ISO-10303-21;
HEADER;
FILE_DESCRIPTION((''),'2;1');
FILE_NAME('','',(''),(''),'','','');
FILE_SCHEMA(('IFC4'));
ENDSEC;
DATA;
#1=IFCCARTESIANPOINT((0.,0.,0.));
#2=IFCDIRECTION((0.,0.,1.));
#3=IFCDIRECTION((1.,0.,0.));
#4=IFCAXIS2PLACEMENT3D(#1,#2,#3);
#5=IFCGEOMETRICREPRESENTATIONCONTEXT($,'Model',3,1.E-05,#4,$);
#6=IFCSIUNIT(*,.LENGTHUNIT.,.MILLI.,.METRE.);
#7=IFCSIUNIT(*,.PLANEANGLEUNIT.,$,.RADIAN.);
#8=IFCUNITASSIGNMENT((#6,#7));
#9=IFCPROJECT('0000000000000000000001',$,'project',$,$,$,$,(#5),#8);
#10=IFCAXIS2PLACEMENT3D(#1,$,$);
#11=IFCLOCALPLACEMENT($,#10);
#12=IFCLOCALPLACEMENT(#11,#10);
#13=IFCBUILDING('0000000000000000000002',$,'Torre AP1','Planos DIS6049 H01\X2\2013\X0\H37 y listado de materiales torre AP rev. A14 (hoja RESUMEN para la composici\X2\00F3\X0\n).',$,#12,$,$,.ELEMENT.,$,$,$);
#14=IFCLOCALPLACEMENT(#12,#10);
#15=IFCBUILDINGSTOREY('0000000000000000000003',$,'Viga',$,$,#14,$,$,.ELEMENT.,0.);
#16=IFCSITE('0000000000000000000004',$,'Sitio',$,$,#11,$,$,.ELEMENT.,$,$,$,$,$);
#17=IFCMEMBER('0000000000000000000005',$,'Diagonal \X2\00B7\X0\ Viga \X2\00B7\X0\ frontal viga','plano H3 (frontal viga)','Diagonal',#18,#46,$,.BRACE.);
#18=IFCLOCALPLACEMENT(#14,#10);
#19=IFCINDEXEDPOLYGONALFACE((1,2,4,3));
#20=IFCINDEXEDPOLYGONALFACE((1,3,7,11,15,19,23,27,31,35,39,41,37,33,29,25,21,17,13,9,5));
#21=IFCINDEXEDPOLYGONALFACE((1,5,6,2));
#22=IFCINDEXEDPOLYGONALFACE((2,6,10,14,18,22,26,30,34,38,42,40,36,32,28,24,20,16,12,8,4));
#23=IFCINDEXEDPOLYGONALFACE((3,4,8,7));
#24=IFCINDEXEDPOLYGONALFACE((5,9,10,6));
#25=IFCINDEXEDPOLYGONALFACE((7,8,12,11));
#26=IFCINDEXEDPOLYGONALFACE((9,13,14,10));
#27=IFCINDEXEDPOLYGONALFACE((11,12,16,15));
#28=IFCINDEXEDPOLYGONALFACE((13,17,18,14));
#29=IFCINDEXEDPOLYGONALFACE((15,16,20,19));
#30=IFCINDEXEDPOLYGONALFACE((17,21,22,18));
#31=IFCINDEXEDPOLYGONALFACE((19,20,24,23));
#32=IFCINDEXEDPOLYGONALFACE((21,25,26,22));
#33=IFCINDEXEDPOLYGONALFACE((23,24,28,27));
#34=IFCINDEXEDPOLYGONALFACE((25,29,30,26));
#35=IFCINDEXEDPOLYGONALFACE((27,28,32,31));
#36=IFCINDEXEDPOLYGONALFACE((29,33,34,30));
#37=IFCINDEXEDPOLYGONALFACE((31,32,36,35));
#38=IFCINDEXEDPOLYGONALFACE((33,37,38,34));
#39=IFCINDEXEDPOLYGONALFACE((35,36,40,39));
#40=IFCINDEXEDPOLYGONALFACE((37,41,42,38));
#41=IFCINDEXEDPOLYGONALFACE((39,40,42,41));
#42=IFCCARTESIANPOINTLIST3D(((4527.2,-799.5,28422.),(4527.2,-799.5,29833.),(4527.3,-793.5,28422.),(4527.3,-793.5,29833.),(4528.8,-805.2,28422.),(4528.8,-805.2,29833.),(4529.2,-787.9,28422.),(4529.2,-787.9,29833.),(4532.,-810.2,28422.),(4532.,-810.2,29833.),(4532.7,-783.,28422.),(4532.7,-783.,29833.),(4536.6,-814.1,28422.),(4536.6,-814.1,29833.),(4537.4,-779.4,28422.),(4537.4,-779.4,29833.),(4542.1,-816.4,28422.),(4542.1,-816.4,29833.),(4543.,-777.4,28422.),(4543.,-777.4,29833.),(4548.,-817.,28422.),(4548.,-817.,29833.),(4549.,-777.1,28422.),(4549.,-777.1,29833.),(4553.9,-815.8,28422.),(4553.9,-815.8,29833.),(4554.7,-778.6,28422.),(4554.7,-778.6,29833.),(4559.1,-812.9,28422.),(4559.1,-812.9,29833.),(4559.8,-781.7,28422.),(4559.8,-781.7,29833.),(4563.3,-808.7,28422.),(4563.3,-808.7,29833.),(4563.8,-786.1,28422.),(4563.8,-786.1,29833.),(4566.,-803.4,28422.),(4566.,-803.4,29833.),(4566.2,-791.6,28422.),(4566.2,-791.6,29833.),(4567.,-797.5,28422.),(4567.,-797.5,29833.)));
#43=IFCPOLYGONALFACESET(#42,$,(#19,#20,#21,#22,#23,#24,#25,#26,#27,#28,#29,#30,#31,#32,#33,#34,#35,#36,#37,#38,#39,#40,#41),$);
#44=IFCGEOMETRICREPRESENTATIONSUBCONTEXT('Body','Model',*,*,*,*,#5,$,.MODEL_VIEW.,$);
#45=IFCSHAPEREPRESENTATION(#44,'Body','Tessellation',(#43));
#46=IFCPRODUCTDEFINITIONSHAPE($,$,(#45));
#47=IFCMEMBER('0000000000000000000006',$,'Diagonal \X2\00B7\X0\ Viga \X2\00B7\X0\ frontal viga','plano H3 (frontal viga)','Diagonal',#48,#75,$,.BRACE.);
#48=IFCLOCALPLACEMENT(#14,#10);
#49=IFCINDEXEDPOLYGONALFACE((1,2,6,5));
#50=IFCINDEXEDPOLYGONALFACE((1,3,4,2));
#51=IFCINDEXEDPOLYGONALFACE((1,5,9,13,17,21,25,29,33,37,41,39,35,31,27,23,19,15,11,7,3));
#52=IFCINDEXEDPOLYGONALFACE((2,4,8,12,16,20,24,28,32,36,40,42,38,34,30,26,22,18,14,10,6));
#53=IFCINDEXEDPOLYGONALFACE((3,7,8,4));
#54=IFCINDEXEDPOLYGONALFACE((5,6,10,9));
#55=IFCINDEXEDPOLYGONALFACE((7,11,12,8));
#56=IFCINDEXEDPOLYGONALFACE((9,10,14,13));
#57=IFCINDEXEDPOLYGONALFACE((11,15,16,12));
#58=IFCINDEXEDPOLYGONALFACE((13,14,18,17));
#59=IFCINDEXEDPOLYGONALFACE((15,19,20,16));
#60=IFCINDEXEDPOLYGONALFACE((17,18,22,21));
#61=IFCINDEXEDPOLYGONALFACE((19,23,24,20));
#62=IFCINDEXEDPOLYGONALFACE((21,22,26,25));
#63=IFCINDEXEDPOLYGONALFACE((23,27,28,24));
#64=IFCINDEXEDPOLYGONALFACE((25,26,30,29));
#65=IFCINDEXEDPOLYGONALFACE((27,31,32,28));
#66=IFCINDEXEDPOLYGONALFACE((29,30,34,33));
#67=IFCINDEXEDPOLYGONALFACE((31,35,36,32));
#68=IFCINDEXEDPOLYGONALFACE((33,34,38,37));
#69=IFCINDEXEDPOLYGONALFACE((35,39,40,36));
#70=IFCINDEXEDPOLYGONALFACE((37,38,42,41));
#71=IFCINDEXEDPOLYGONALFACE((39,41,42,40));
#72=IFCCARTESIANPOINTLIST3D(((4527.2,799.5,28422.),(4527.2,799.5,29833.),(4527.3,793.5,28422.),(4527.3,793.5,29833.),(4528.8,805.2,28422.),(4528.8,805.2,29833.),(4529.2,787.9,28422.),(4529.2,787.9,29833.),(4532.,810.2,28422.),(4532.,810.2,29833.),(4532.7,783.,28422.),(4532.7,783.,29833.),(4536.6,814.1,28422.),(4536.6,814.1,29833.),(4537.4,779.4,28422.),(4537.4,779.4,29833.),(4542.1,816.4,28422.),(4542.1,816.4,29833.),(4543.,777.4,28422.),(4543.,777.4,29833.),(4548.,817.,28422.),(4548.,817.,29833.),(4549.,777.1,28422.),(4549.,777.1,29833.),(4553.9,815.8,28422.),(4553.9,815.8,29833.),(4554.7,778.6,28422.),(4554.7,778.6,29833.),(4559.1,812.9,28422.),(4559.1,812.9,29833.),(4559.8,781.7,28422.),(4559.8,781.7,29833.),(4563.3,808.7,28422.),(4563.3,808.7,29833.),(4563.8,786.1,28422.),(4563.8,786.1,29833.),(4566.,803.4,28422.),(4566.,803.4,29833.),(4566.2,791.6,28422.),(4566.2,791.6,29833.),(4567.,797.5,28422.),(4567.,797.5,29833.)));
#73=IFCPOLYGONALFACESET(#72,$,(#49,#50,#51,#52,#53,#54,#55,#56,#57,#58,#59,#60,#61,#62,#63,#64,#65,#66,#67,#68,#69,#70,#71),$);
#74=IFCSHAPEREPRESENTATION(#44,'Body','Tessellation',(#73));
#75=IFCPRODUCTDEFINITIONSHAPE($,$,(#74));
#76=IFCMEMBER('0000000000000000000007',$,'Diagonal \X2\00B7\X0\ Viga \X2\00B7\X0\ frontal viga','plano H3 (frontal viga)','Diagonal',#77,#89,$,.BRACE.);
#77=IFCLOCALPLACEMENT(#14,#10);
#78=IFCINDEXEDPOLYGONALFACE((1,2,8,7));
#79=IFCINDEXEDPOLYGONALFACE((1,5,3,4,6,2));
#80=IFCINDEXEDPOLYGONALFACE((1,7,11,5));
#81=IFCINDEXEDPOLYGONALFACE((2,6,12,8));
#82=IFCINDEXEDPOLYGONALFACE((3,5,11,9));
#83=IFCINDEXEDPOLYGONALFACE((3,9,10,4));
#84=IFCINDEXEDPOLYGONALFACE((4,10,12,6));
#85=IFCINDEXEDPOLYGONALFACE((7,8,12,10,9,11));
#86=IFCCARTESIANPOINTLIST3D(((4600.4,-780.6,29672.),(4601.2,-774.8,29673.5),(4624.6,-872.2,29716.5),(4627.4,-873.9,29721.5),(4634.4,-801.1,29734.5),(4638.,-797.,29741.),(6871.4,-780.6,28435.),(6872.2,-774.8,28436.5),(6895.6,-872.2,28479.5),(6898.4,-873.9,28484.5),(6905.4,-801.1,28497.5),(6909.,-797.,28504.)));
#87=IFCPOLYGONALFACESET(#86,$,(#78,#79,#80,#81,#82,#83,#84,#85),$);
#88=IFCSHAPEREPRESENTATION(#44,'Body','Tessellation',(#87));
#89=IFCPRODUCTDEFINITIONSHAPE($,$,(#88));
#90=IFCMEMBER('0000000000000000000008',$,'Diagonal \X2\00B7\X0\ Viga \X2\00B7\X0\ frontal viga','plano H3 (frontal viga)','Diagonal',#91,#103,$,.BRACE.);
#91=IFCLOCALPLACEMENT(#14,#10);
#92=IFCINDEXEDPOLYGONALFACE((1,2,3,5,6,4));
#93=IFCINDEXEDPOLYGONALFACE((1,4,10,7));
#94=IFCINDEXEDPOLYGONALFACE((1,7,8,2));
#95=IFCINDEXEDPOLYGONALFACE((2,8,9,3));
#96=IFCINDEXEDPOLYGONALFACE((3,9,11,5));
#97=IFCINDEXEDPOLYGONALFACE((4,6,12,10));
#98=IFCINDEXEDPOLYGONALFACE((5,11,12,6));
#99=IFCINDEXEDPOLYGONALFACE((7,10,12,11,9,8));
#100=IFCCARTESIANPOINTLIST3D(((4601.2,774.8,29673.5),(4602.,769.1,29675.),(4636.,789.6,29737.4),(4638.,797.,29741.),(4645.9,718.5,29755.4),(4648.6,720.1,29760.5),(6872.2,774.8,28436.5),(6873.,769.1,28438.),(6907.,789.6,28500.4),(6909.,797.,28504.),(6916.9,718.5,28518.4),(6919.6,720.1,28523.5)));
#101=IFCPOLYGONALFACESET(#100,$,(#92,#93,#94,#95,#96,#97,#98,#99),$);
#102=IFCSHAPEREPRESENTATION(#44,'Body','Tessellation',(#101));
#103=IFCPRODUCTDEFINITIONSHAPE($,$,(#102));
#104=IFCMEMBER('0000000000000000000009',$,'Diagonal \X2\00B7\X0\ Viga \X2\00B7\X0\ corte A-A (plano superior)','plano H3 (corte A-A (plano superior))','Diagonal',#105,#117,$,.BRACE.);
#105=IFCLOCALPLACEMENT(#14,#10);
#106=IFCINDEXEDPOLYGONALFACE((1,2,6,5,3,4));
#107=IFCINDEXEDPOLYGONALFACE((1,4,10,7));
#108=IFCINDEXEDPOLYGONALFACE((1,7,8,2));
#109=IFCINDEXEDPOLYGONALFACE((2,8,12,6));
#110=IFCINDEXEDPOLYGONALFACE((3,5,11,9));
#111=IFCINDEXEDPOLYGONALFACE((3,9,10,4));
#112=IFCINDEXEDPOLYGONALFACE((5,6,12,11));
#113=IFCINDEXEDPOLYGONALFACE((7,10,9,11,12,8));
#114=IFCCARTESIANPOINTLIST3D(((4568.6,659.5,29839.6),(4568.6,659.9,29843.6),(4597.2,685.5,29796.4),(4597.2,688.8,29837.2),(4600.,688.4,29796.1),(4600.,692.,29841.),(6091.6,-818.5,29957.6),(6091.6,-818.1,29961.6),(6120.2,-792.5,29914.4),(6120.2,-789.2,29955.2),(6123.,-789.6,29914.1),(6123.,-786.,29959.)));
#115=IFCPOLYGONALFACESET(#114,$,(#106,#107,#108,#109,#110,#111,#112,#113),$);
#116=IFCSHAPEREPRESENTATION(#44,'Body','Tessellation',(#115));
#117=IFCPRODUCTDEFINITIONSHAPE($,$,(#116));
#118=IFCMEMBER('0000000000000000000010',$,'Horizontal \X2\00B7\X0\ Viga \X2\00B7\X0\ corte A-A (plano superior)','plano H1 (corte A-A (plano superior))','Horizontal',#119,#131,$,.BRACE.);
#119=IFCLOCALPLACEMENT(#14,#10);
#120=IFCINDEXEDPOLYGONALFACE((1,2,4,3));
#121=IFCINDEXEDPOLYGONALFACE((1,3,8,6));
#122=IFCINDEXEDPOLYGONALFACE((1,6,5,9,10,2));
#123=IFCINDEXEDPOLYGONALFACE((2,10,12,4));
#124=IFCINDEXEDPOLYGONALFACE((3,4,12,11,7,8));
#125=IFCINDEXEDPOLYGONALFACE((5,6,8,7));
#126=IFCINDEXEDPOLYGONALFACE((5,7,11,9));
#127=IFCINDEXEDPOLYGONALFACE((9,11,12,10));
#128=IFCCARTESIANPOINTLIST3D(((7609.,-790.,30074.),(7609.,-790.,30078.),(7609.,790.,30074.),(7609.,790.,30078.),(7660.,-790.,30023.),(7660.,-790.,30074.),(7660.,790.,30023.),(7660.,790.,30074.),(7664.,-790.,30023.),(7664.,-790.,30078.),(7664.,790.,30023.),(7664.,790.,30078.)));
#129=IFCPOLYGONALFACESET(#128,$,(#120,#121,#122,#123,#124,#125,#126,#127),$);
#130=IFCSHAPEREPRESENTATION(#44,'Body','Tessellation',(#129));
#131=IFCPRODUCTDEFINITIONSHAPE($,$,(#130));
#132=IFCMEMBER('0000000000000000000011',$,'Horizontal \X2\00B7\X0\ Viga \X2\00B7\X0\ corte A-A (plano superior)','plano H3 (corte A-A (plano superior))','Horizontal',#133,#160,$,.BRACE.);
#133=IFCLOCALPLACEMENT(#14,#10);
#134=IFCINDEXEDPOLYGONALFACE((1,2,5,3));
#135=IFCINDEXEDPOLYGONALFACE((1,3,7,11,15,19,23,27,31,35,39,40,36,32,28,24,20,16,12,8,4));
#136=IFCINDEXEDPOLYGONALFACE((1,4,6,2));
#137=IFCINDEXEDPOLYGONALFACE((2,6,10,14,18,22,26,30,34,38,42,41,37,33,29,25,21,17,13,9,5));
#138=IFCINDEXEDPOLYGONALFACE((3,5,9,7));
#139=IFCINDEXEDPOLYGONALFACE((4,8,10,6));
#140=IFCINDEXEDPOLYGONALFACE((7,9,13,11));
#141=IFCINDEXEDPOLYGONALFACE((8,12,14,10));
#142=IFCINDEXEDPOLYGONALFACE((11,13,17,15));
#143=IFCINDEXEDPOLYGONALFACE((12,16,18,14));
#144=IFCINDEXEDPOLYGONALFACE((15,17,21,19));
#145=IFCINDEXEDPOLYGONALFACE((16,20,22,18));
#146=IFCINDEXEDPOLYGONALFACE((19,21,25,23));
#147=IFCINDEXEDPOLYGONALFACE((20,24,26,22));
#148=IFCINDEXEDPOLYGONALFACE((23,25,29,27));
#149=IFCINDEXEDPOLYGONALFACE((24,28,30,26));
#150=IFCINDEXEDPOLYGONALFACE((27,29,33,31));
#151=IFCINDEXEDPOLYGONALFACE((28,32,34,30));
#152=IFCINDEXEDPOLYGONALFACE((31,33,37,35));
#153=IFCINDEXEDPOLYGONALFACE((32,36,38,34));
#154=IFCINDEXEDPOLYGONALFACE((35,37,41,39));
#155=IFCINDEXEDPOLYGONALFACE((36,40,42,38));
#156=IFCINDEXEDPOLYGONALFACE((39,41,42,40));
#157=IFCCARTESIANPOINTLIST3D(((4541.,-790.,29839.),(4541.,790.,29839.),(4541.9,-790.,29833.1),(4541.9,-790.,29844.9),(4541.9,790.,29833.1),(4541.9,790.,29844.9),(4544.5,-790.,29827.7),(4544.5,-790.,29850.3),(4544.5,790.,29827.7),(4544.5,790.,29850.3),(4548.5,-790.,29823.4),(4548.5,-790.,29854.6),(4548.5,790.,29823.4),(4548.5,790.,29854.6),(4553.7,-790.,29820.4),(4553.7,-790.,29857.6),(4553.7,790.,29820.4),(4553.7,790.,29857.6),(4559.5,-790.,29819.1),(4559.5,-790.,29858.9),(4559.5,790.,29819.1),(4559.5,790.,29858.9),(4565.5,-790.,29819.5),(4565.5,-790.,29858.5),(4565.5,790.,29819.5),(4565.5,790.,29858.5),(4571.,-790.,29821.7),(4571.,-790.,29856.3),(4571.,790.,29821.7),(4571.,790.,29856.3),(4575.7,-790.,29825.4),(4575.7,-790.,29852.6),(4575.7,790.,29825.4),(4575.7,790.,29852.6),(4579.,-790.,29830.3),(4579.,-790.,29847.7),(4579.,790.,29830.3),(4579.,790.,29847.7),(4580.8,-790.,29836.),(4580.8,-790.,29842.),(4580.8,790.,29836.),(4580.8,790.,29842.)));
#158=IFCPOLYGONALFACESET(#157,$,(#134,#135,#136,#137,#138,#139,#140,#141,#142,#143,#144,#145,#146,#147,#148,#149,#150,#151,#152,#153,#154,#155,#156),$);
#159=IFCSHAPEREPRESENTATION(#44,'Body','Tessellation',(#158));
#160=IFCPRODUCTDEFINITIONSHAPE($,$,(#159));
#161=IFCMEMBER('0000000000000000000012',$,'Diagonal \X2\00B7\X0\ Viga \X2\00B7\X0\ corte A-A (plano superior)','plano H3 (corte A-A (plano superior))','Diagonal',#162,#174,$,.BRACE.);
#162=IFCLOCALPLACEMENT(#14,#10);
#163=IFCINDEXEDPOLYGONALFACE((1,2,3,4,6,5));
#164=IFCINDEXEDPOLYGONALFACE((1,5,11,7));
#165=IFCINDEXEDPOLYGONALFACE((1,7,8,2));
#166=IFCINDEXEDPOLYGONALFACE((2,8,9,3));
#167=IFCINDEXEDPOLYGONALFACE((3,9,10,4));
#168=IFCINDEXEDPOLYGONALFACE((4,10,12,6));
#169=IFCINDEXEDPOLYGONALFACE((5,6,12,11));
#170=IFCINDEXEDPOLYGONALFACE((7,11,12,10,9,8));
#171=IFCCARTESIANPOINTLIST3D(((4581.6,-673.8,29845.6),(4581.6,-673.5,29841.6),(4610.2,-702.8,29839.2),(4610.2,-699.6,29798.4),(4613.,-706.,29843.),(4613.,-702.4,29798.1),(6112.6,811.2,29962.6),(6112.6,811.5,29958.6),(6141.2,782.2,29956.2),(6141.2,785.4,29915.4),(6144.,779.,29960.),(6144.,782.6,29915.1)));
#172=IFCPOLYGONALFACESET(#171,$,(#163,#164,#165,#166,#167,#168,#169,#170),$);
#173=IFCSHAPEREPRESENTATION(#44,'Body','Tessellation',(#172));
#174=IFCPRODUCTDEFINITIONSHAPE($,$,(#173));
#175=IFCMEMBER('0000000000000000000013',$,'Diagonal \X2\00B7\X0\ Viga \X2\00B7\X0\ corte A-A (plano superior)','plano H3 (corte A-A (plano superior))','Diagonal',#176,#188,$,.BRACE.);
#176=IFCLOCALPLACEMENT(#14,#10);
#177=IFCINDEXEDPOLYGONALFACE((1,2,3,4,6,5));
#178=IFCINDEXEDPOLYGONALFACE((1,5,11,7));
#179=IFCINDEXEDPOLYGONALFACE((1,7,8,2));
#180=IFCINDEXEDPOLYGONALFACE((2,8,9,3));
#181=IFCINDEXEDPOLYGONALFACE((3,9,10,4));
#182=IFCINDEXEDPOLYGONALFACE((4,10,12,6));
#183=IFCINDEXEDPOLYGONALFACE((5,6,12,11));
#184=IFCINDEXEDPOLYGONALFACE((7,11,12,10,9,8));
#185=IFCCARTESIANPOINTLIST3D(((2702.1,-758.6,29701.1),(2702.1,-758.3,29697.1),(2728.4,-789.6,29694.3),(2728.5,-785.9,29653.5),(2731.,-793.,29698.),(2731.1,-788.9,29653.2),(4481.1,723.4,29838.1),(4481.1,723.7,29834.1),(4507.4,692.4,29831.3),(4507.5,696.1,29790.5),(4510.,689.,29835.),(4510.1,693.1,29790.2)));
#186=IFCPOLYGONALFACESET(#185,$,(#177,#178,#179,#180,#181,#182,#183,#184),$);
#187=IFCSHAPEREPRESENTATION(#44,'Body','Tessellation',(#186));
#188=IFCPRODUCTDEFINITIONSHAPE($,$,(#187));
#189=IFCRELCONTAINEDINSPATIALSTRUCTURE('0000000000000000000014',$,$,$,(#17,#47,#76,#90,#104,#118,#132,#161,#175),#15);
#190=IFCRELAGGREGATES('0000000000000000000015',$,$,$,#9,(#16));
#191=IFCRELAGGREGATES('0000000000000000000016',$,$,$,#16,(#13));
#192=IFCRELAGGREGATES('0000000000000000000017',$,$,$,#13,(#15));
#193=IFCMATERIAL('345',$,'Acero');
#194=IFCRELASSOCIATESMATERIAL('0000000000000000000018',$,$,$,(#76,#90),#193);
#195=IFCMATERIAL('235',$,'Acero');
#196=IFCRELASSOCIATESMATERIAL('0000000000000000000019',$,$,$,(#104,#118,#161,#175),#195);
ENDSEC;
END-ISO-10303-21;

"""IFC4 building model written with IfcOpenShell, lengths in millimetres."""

from ifc_helpers import new_model, si_unit, frame, frame_2d, origin, origin_with_axes, place, context, subcontext, project, spatial, circle, l_section, extrude, material, element, save


model = new_model("IFC4")

# Units and contexts
model_context = context("Model", 3, precision=1e-05, world=origin_with_axes())
body_context = subcontext(model_context, "Body", "Model", "MODEL_VIEW")
ifc_project = project(units=[si_unit("LENGTHUNIT", "METRE", prefix="MILLI"), si_unit("PLANEANGLEUNIT", "RADIAN")], contexts=[model_context])

# Site, building, storey
site_placement = place(None, origin())
site = spatial("IfcSite", under=ifc_project, at=site_placement, Name="Sitio", CompositionType="ELEMENT")
building_placement = place(site_placement, origin())
building = spatial("IfcBuilding", under=site, at=building_placement, Name="Torre AP1", Description="Planos DIS6049 H01–H37 y listado de materiales torre AP rev. A14 (hoja RESUMEN para la composición).", CompositionType="ELEMENT")
storey_placement = place(building_placement, origin())
storey = spatial("IfcBuildingStorey", under=building, at=storey_placement, Name="Viga", CompositionType="ELEMENT", Elevation=0.0)

# Members
ifc_material_1 = material(Name="235", Category="Acero")
ifc_material_2 = material(Name="345", Category="Acero")
for number, where, z_axis, x_axis, name in (
    (1, (4547.0, -797.0, 28422.0), (0.0, 0.0, 1.0), (-0.984984, 0.172648, 0.0), "Diagonal · Viga · frontal viga"),
    (2, (4547.0, 797.0, 28422.0), (0.0, 0.0, 1.0), (-0.984984, -0.172648, 0.0), "Diagonal · Viga · frontal viga"),
):
    element("IfcMember", number, at=place(storey_placement, frame(where, z_axis=z_axis, x_axis=x_axis)), inside=storey, Name=name, Description="plano H3 (frontal viga)", ObjectType="Diagonal", PredefinedType="BRACE", context=body_context, shape_type="SweptSolid", body=[
        extrude(circle(Radius=20.0), None, (0.0, 0.0, 1.0), 1411.0),
    ])
for number, where, z_axis, x_axis, name in (
    (3, (6909.0, -797.0, 28504.0), (-0.878176, 0.0, 0.478337), (-0.459582, 0.277277, -0.843743), "Diagonal · Viga · frontal viga"),
    (4, (6909.0, 797.0, 28504.0), (-0.878176, 0.0, 0.478337), (-0.459582, -0.277277, -0.843743), "Diagonal · Viga · frontal viga"),
):
    element("IfcMember", number, at=place(storey_placement, frame(where, z_axis=z_axis, x_axis=x_axis)), inside=storey, material=ifc_material_2, Name=name, Description="plano H3 (frontal viga)", ObjectType="Diagonal", PredefinedType="BRACE", context=body_context, shape_type="SweptSolid", body=[
        extrude(l_section(Depth=80.0, Width=80.0, Thickness=6.0, at=frame_2d((40.0, 40.0))), None, (0.0, 0.0, 1.0), 2586.0),
    ])
member_1_placement = place(storey_placement, frame((4600.0, 692.0, 29841.0), z_axis=(0.716522, -0.695351, 0.055515), x_axis=(-0.697564, -0.714169, 0.05803)))
element("IfcMember", 5, at=member_1_placement, inside=storey, material=ifc_material_1, Name="Diagonal · Viga · corte A-A (plano superior)", Description="plano H3 (corte A-A (plano superior))", ObjectType="Diagonal", PredefinedType="BRACE", context=body_context, shape_type="SweptSolid", body=[
    extrude(l_section(Depth=45.0, Width=45.0, Thickness=4.0, at=frame_2d((22.5, 22.5))), None, (0.0, 0.0, 1.0), 2125.5),
])
member_2_placement = place(storey_placement, frame((7664.0, 790.0, 30078.0), z_axis=(0.0, -1.0, 0.0), x_axis=(-1.0, 0.0, 0.0)))
element("IfcMember", 6, at=member_2_placement, inside=storey, material=ifc_material_1, Name="Horizontal · Viga · corte A-A (plano superior)", Description="plano H1 (corte A-A (plano superior))", ObjectType="Horizontal", PredefinedType="BRACE", context=body_context, shape_type="SweptSolid", body=[
    extrude(l_section(Depth=55.0, Width=55.0, Thickness=4.0, at=frame_2d((27.5, 27.5))), None, (0.0, 0.0, 1.0), 1580.0),
])
member_3_placement = place(storey_placement, frame((4561.0, 790.0, 29839.0), z_axis=(0.0, -1.0, 0.0), x_axis=(-1.0, 0.0, 0.0)))
element("IfcMember", 7, at=member_3_placement, inside=storey, Name="Horizontal · Viga · corte A-A (plano superior)", Description="plano H3 (corte A-A (plano superior))", ObjectType="Horizontal", PredefinedType="BRACE", context=body_context, shape_type="SweptSolid", body=[
    extrude(circle(Radius=20.0), None, (0.0, 0.0, 1.0), 1580.0),
])
member_4_placement = place(storey_placement, frame((6144.0, 779.0, 29960.0), z_axis=(-0.716731, -0.695196, -0.054773), x_axis=(-0.69735, 0.714456, 0.057063)))
element("IfcMember", 8, at=member_4_placement, inside=storey, material=ifc_material_1, Name="Diagonal · Viga · corte A-A (plano superior)", Description="plano H3 (corte A-A (plano superior))", ObjectType="Diagonal", PredefinedType="BRACE", context=body_context, shape_type="SweptSolid", body=[
    extrude(l_section(Depth=45.0, Width=45.0, Thickness=4.0, at=frame_2d((22.5, 22.5))), None, (0.0, 0.0, 1.0), 2136.1),
])
member_5_placement = place(storey_placement, frame((4510.0, 689.0, 29835.0), z_axis=(-0.766986, -0.638939, -0.059065), x_axis=(-0.641662, 0.763915, 0.068584)))
element("IfcMember", 9, at=member_5_placement, inside=storey, material=ifc_material_1, Name="Diagonal · Viga · corte A-A (plano superior)", Description="plano H3 (corte A-A (plano superior))", ObjectType="Diagonal", PredefinedType="BRACE", context=body_context, shape_type="SweptSolid", body=[
    extrude(l_section(Depth=45.0, Width=45.0, Thickness=4.0, at=frame_2d((22.5, 22.5))), None, (0.0, 0.0, 1.0), 2319.5),
])

save(model, "model.ifc")
